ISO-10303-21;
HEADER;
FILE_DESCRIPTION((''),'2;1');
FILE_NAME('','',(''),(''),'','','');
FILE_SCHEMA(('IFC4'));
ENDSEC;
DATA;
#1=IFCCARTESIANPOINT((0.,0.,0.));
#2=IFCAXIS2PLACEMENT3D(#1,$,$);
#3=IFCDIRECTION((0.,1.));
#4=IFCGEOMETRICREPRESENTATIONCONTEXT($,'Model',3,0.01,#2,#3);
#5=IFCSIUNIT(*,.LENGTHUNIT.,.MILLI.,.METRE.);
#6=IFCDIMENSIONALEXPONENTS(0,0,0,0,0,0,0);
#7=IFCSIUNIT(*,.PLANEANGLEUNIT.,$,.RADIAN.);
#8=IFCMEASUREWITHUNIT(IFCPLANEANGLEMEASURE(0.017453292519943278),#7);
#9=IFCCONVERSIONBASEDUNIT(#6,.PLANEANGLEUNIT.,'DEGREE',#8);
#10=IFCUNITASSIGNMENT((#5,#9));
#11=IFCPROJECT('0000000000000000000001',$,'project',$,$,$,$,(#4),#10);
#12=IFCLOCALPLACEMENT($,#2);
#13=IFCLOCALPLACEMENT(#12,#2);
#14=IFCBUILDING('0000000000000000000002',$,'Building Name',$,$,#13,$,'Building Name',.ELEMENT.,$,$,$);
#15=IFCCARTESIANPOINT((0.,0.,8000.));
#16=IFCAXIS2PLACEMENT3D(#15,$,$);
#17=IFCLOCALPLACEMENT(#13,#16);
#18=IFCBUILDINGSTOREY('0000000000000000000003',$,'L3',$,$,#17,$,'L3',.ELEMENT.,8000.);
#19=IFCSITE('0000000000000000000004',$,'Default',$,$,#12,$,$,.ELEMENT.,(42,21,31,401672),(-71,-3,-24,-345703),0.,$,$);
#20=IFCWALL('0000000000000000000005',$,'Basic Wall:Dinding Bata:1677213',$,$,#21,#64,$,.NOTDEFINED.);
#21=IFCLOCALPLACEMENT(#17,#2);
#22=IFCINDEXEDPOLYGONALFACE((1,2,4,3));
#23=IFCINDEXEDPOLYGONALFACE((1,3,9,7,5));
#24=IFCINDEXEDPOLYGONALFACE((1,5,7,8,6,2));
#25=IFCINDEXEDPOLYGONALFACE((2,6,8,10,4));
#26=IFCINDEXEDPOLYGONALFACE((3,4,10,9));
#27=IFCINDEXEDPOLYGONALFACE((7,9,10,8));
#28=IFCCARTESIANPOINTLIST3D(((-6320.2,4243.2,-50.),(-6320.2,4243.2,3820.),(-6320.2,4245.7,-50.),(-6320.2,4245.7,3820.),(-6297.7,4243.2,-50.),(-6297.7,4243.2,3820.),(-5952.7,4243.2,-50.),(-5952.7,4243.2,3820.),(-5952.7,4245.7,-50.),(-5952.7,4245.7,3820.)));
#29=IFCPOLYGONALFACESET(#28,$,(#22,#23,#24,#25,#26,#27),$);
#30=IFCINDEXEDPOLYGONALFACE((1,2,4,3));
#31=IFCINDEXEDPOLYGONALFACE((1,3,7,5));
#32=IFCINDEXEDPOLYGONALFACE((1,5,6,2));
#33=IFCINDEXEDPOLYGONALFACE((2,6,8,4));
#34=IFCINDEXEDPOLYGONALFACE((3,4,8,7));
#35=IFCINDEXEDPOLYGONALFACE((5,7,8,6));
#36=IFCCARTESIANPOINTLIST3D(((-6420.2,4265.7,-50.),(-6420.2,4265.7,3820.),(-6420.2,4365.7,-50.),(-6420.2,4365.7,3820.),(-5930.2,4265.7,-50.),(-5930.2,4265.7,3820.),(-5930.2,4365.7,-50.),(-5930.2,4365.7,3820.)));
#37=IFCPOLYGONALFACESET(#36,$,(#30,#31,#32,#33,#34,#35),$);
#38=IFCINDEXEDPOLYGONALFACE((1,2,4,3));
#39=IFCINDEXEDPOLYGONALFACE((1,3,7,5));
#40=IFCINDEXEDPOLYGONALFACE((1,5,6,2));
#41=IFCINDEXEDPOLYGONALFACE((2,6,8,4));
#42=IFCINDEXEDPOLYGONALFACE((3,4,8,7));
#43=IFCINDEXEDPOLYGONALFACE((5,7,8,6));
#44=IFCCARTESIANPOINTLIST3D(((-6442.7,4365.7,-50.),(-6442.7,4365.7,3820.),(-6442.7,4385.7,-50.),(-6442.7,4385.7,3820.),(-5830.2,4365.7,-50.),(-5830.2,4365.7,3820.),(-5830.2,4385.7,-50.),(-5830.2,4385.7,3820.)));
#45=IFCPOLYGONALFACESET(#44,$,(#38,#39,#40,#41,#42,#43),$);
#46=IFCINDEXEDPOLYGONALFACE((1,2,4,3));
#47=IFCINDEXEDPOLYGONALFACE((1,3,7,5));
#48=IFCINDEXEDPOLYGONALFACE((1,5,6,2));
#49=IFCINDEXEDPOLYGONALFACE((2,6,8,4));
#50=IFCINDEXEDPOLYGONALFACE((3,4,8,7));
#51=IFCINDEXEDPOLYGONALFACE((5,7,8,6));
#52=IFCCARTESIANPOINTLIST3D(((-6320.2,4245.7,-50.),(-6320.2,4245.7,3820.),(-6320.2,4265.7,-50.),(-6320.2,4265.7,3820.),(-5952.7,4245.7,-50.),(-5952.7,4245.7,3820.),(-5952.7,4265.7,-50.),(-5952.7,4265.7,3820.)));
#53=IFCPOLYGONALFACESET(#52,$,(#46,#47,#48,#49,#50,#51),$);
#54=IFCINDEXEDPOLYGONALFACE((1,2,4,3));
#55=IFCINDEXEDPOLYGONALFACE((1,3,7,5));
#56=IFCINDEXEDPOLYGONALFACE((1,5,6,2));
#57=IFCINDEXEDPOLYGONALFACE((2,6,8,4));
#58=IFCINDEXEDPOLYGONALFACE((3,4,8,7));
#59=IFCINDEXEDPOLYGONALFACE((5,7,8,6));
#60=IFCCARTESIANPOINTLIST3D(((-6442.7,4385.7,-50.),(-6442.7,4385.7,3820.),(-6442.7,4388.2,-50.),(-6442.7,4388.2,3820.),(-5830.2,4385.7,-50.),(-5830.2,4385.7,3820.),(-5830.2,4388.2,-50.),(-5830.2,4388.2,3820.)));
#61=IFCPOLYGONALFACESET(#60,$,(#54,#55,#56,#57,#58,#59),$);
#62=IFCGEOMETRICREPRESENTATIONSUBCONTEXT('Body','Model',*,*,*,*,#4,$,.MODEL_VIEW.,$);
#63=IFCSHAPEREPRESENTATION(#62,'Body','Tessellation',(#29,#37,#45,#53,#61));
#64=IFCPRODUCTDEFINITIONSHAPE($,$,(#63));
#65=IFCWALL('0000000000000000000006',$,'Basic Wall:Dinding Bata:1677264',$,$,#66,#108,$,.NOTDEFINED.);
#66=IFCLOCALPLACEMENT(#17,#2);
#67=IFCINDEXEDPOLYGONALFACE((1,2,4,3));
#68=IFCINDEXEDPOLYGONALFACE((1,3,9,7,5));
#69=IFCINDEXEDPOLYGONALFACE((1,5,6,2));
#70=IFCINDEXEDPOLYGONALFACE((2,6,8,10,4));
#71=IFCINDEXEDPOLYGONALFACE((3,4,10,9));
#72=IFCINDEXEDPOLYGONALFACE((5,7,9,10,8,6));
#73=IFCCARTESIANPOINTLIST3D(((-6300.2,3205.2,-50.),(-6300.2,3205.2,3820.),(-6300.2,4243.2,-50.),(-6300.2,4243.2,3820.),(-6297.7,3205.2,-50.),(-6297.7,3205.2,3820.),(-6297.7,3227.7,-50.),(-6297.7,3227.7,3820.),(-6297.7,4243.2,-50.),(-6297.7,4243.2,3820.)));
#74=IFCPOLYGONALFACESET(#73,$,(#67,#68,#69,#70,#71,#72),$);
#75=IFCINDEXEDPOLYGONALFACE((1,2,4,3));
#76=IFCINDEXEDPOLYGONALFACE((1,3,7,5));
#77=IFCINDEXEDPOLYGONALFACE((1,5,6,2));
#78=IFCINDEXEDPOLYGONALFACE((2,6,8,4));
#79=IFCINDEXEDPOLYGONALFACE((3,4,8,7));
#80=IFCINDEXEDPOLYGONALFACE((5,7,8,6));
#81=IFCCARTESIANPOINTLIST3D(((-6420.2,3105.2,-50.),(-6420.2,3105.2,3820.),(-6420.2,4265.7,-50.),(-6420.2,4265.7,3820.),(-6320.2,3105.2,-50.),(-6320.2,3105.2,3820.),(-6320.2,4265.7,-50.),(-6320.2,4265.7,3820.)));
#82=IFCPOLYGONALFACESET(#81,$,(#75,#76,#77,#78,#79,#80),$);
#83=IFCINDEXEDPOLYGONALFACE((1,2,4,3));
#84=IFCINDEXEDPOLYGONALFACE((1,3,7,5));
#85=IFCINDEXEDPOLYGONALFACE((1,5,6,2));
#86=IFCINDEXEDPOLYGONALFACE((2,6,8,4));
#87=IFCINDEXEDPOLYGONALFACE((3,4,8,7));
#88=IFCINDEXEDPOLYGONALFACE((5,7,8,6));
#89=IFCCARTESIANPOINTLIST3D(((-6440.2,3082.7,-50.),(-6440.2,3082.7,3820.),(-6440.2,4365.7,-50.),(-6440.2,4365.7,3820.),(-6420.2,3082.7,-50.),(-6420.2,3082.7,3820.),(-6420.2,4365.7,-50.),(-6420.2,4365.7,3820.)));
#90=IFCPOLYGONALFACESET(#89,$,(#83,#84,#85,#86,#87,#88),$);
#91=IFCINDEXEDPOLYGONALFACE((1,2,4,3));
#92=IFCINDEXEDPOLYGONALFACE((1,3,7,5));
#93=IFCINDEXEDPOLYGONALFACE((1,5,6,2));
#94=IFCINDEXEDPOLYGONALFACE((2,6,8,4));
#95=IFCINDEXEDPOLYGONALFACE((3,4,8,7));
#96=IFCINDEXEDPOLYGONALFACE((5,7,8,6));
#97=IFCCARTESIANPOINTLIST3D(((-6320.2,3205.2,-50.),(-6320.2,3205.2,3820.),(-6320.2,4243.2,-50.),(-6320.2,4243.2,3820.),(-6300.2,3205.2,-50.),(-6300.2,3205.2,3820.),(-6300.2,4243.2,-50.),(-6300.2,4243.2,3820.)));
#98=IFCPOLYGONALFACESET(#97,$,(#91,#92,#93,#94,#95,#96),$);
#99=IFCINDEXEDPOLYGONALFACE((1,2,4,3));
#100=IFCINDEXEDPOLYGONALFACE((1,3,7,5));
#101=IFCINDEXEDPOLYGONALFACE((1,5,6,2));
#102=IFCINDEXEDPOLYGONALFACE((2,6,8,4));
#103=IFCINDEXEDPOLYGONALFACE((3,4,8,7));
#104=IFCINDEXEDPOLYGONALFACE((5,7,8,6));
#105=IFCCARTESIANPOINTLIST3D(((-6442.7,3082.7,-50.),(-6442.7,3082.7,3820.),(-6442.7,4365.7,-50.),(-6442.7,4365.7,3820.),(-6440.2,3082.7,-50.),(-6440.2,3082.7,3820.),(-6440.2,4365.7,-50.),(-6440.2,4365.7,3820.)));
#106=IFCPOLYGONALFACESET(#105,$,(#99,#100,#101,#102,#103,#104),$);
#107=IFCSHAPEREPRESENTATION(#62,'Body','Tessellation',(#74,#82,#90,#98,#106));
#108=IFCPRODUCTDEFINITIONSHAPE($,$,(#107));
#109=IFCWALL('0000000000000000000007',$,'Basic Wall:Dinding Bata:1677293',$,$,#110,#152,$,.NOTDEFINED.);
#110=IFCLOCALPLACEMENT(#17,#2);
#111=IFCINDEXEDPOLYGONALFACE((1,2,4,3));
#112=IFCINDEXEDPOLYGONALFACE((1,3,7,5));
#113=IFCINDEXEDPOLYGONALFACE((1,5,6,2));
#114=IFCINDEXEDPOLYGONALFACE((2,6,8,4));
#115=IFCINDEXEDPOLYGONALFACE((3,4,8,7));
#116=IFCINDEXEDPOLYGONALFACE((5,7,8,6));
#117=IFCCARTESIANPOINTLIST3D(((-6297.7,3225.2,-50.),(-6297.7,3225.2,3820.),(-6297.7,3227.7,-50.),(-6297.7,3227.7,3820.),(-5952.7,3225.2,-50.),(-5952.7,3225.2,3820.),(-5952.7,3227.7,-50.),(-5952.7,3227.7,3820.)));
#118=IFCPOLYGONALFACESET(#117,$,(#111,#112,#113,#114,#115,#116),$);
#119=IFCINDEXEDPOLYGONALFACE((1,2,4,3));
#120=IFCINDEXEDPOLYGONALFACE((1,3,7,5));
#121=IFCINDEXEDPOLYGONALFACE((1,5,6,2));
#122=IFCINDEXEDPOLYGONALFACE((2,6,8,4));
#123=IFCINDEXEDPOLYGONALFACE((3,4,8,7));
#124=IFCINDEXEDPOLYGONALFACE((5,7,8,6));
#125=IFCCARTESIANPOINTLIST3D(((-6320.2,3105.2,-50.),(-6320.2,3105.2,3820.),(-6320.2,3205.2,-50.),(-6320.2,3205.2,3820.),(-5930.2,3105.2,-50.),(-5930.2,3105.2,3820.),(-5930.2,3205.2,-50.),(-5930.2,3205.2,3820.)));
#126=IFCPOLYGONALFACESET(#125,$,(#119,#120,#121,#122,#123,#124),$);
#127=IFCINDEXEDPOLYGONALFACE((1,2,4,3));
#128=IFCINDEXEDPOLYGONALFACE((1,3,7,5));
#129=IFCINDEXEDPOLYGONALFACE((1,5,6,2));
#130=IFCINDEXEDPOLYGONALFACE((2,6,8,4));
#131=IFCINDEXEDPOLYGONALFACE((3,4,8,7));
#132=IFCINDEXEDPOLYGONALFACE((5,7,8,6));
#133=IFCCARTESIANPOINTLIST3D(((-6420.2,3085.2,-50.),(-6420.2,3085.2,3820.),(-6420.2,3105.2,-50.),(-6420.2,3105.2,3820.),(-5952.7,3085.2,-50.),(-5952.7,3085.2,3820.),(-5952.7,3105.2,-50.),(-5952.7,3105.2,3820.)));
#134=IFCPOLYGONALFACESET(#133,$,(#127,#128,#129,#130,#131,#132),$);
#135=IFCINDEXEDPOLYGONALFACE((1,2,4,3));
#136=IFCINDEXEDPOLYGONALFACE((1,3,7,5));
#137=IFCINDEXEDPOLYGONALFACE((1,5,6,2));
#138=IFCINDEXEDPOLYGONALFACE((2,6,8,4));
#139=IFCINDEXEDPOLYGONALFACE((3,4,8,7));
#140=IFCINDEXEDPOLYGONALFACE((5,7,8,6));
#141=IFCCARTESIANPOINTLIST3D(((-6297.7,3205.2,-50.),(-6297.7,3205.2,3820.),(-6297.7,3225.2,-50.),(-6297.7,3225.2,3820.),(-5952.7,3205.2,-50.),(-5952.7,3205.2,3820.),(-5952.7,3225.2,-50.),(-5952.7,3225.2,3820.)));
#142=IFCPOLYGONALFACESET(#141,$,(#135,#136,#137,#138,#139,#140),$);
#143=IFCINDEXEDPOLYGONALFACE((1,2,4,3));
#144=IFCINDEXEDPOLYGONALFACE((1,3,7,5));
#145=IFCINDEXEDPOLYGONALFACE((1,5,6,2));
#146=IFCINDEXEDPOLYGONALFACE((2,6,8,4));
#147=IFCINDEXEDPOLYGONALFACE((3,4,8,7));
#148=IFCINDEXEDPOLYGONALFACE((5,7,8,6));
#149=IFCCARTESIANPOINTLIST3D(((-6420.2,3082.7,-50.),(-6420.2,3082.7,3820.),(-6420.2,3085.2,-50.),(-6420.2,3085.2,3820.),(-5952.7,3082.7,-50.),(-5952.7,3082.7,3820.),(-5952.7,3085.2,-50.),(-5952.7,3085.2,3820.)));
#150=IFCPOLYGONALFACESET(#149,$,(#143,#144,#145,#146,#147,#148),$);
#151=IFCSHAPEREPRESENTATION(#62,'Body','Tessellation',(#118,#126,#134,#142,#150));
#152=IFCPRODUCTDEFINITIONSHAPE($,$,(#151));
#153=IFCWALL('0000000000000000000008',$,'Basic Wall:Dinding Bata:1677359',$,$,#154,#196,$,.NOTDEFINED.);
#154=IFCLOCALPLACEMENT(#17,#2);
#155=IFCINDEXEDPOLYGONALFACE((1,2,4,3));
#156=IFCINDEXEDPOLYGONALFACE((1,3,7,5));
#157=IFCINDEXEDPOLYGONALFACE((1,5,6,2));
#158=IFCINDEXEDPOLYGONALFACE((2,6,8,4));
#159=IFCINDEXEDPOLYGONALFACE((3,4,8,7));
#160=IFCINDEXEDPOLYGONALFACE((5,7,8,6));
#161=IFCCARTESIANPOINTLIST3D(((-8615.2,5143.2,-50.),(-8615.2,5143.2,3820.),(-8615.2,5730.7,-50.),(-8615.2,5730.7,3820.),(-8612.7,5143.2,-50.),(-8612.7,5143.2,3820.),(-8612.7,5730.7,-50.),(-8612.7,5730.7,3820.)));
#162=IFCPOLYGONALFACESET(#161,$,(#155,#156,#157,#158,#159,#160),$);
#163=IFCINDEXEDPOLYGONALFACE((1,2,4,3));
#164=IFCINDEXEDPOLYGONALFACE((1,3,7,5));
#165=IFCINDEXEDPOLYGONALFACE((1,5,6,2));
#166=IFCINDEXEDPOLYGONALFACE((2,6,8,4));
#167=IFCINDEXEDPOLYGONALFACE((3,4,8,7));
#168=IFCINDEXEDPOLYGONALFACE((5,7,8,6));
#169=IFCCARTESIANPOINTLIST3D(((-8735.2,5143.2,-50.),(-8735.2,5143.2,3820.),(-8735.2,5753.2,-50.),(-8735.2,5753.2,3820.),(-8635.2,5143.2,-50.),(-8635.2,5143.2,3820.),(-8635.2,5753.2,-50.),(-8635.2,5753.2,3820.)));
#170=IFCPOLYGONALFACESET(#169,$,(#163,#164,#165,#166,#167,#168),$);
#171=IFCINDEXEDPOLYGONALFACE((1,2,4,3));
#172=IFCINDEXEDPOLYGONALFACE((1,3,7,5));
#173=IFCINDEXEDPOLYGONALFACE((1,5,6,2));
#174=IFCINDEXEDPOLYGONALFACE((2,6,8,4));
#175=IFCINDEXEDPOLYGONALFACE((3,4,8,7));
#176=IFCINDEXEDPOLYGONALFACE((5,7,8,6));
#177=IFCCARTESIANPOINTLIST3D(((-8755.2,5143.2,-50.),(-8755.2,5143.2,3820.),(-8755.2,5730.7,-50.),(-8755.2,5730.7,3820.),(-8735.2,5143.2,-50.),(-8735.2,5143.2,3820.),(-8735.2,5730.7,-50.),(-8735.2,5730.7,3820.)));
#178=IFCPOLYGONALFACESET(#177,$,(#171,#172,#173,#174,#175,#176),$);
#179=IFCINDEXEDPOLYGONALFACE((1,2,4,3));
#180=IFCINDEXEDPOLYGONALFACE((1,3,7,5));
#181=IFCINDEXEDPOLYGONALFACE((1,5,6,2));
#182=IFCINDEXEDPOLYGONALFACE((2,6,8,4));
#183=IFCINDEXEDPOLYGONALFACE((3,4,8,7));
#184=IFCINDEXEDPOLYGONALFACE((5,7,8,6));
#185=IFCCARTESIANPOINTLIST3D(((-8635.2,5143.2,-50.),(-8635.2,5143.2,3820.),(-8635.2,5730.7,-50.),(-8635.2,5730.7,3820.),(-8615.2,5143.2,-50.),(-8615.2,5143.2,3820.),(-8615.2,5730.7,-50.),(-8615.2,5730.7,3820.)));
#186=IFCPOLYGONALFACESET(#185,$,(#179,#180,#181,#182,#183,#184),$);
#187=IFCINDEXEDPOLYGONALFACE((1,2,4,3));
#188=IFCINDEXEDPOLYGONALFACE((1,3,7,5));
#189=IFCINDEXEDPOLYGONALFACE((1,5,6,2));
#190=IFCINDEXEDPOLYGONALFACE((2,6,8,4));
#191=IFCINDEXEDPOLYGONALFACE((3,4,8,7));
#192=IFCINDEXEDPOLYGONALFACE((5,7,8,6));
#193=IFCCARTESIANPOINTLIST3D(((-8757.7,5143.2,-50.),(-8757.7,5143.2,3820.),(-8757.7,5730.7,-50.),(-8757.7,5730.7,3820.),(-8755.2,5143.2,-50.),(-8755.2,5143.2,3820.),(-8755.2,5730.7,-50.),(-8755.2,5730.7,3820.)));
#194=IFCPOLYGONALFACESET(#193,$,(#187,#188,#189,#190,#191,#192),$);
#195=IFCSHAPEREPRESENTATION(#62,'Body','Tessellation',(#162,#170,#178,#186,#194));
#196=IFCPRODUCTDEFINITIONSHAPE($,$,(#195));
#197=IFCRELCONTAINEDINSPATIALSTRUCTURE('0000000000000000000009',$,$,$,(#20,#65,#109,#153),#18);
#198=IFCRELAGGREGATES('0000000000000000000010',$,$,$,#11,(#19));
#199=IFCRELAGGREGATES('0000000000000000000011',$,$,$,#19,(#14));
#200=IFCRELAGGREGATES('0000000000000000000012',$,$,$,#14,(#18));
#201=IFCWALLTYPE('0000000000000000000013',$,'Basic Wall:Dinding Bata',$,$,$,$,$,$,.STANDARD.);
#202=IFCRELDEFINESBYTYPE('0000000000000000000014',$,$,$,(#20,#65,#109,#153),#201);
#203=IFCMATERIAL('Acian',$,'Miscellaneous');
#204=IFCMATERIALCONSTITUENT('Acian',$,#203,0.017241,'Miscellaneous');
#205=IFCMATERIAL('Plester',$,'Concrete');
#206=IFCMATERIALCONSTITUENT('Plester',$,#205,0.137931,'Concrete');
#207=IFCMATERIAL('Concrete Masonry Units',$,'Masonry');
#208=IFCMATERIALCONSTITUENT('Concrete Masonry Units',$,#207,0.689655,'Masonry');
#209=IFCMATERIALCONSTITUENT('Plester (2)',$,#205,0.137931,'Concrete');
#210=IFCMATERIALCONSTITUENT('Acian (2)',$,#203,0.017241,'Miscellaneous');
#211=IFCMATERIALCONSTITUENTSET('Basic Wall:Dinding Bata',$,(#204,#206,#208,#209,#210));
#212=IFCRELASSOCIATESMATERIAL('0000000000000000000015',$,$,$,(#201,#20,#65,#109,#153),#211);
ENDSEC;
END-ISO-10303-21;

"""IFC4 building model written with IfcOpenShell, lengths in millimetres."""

from ifc_helpers import new_model, entity, si_unit, converted_unit, direction, frame, origin, place, context, subcontext, project, spatial, indexed_curve, outline, extrude, material, constituent, constituent_set, type_object, element, save


model = new_model("IFC4")

# Units and contexts
model_context = context("Model", 3, precision=0.01, world=origin(), true_north=direction((0.0, 1.0)))
body_context = subcontext(model_context, "Body", "Model", "MODEL_VIEW")
ifc_project = project(units=[si_unit("LENGTHUNIT", "METRE", prefix="MILLI"), converted_unit("PLANEANGLEUNIT", "DEGREE", entity("IfcPlaneAngleMeasure", 0.017453292519943278), si_unit("PLANEANGLEUNIT", "RADIAN"), dimensions=[0, 0, 0, 0, 0, 0, 0])], contexts=[model_context])

# Site, building, storey
site_placement = place(None, origin())
site = spatial("IfcSite", under=ifc_project, at=site_placement, Name="Default", CompositionType="ELEMENT", RefLatitude=(42, 21, 31, 401672), RefLongitude=(-71, -3, -24, -345703), RefElevation=0.0)
building_placement = place(site_placement, origin())
building = spatial("IfcBuilding", under=site, at=building_placement, Name="Building Name", LongName="Building Name", CompositionType="ELEMENT")
storey_placement = place(building_placement, frame((0.0, 0.0, 8000.0)))
storey = spatial("IfcBuildingStorey", under=building, at=storey_placement, Name="L3", LongName="L3", CompositionType="ELEMENT", Elevation=8000.0)

# Walls
ifc_material_1 = material(Name="Acian", Category="Miscellaneous")
ifc_constituent_1 = constituent(ifc_material_1, Name="Acian", Category="Miscellaneous", fraction=0.017241)
ifc_material_2 = material(Name="Plester", Category="Concrete")
ifc_constituent_2 = constituent(ifc_material_2, Name="Plester", Category="Concrete", fraction=0.137931)
ifc_material_3 = material(Name="Concrete Masonry Units", Category="Masonry")
ifc_constituent_3 = constituent(ifc_material_3, Name="Concrete Masonry Units", Category="Masonry", fraction=0.689655)
ifc_constituent_4 = constituent(ifc_material_2, Name="Plester (2)", Category="Concrete", fraction=0.137931)
ifc_constituent_5 = constituent(ifc_material_1, Name="Acian (2)", Category="Miscellaneous", fraction=0.017241)
ifc_constituent_set = constituent_set(constituents=[ifc_constituent_1, ifc_constituent_2, ifc_constituent_3, ifc_constituent_4, ifc_constituent_5], Name="Basic Wall:Dinding Bata")
wall_type = type_object("IfcWallType", Name="Basic Wall:Dinding Bata", PredefinedType="STANDARD", material=ifc_constituent_set)
wall_1_placement = place(storey_placement, frame((-5952.7, 4315.7, -50.0), z_axis=(0.0, 0.0, 1.0), x_axis=(-1.0, 0.0, 0.0)))
element("IfcWall", 1, at=wall_1_placement, inside=storey, type_object=wall_type, material=ifc_constituent_set, Name="Basic Wall:Dinding Bata:1677213", PredefinedType="NOTDEFINED", context=body_context, shape_type="SweptSolid", body=[
    extrude(outline(indexed_curve([(-129.0, -1.0), (216.0, -1.0), (216.0, 1.5), (-151.5, 1.5), (-151.5, -1.0), (-129.0, -1.0)], self_intersect=False)), frame((216.0, 71.5, 0.0), z_axis=(0.0, 0.0, 1.0), x_axis=(-1.0, 0.0, 0.0)), (0.0, 0.0, 1.0), 3870.0),
    extrude(outline(indexed_curve([(-245.0, -50.0), (245.0, -50.0), (245.0, 50.0), (-245.0, 50.0), (-245.0, -50.0)], self_intersect=False)), frame((222.5, 0.0, 0.0)), (0.0, 0.0, 1.0), 3870.0),
    extrude(outline(indexed_curve([(-306.3, -10.0), (306.3, -10.0), (306.3, 10.0), (-306.3, 10.0), (-306.3, -10.0)], self_intersect=False)), frame((183.8, -60.0, 0.0)), (0.0, 0.0, 1.0), 3870.0),
    extrude(outline(indexed_curve([(-183.8, -10.0), (183.8, -10.0), (183.8, 10.0), (-183.8, 10.0), (-183.8, -10.0)], self_intersect=False)), frame((183.8, 60.0, 0.0)), (0.0, 0.0, 1.0), 3870.0),
    extrude(outline(indexed_curve([(-1.3, -306.3), (1.2, -306.3), (1.3, 306.3), (-1.2, 306.3), (-1.3, -306.3)], self_intersect=False)), frame((183.8, -71.3, 0.0), z_axis=(0.0, 0.0, 1.0), x_axis=(0.0, 1.0, 0.0)), (0.0, 0.0, 1.0), 3870.0),
])
wall_2_placement = place(storey_placement, frame((-6370.2, 4243.2, -50.0), z_axis=(0.0, 0.0, 1.0), x_axis=(0.0, -1.0, 0.0)))
element("IfcWall", 2, at=wall_2_placement, inside=storey, type_object=wall_type, material=ifc_constituent_set, Name="Basic Wall:Dinding Bata:1677264", PredefinedType="NOTDEFINED", context=body_context, shape_type="SweptSolid", body=[
    extrude(outline(indexed_curve([(-397.2, -1.0), (618.3, -1.0), (618.3, 1.5), (-419.7, 1.5), (-419.7, -1.0), (-397.2, -1.0)], self_intersect=False)), frame((618.3, 71.5, 0.0), z_axis=(0.0, 0.0, 1.0), x_axis=(-1.0, 0.0, 0.0)), (0.0, 0.0, 1.0), 3870.0),
    extrude(outline(indexed_curve([(-580.2, -50.0), (580.2, -50.0), (580.2, 50.0), (-580.2, 50.0), (-580.2, -50.0)], self_intersect=False)), frame((557.7, 0.0, 0.0)), (0.0, 0.0, 1.0), 3870.0),
    extrude(outline(indexed_curve([(-641.5, -10.0), (641.5, -10.0), (641.5, 10.0), (-641.5, 10.0), (-641.5, -10.0)], self_intersect=False)), frame((519.0, -60.0, 0.0)), (0.0, 0.0, 1.0), 3870.0),
    extrude(outline(indexed_curve([(-519.0, -10.0), (519.0, -10.0), (519.0, 10.0), (-519.0, 10.0), (-519.0, -10.0)], self_intersect=False)), frame((519.0, 60.0, 0.0)), (0.0, 0.0, 1.0), 3870.0),
    extrude(outline(indexed_curve([(-1.3, -641.5), (1.2, -641.5), (1.3, 641.5), (-1.2, 641.5), (-1.3, -641.5)], self_intersect=False)), frame((519.0, -71.3, 0.0), z_axis=(0.0, 0.0, 1.0), x_axis=(0.0, 1.0, 0.0)), (0.0, 0.0, 1.0), 3870.0),
])
wall_3_placement = place(storey_placement, frame((-6297.7, 3155.2, -50.0)))
element("IfcWall", 3, at=wall_3_placement, inside=storey, type_object=wall_type, material=ifc_constituent_set, Name="Basic Wall:Dinding Bata:1677293", PredefinedType="NOTDEFINED", context=body_context, shape_type="SweptSolid", body=[
    extrude(outline(indexed_curve([(-1.3, -172.5), (1.2, -172.5), (1.3, 172.5), (-1.2, 172.5), (-1.3, -172.5)], self_intersect=False)), frame((172.5, 71.3, 0.0), z_axis=(0.0, 0.0, 1.0), x_axis=(0.0, -1.0, 0.0)), (0.0, 0.0, 1.0), 3870.0),
    extrude(outline(indexed_curve([(-195.0, -50.0), (195.0, -50.0), (195.0, 50.0), (-195.0, 50.0), (-195.0, -50.0)], self_intersect=False)), frame((172.5, 0.0, 0.0)), (0.0, 0.0, 1.0), 3870.0),
    extrude(outline(indexed_curve([(-233.8, -10.0), (233.8, -10.0), (233.8, 10.0), (-233.8, 10.0), (-233.8, -10.0)], self_intersect=False)), frame((111.3, -60.0, 0.0)), (0.0, 0.0, 1.0), 3870.0),
    extrude(outline(indexed_curve([(-172.5, -10.0), (172.5, -10.0), (172.5, 10.0), (-172.5, 10.0), (-172.5, -10.0)], self_intersect=False)), frame((172.5, 60.0, 0.0)), (0.0, 0.0, 1.0), 3870.0),
    extrude(outline(indexed_curve([(-1.3, -233.8), (1.2, -233.8), (1.3, 233.8), (-1.2, 233.8), (-1.3, -233.8)], self_intersect=False)), frame((111.3, -71.3, 0.0), z_axis=(0.0, 0.0, 1.0), x_axis=(0.0, 1.0, 0.0)), (0.0, 0.0, 1.0), 3870.0),
])
wall_4_placement = place(storey_placement, frame((-8685.2, 5730.7, -50.0), z_axis=(0.0, 0.0, 1.0), x_axis=(0.0, -1.0, 0.0)))
element("IfcWall", 4, at=wall_4_placement, inside=storey, type_object=wall_type, material=ifc_constituent_set, Name="Basic Wall:Dinding Bata:1677359", PredefinedType="NOTDEFINED", context=body_context, shape_type="SweptSolid", body=[
    extrude(outline(indexed_curve([(-1.3, -293.8), (1.2, -293.8), (1.2, 293.7), (-1.2, 293.7), (-1.3, -293.8)], self_intersect=False)), frame((293.8, 71.2, 0.0), z_axis=(0.0, 0.0, 1.0), x_axis=(0.0, -1.0, 0.0)), (0.0, 0.0, 1.0), 3870.0),
    extrude(outline(indexed_curve([(-305.0, -50.0), (305.0, -50.0), (305.0, 50.0), (-305.0, 50.0), (-305.0, -50.0)], self_intersect=False)), frame((282.5, 0.0, 0.0)), (0.0, 0.0, 1.0), 3870.0),
    extrude(outline(indexed_curve([(-293.8, -10.0), (293.8, -10.0), (293.8, 10.0), (-293.8, 10.0), (-293.8, -10.0)], self_intersect=False)), frame((293.8, -60.0, 0.0)), (0.0, 0.0, 1.0), 3870.0),
    extrude(outline(indexed_curve([(-293.8, -10.0), (293.7, -10.0), (293.7, 10.0), (-293.8, 10.0), (-293.8, -10.0)], self_intersect=False)), frame((293.8, 60.0, 0.0)), (0.0, 0.0, 1.0), 3870.0),
    extrude(outline(indexed_curve([(-1.2, -293.8), (1.2, -293.8), (1.3, 293.8), (-1.2, 293.8), (-1.2, -293.8)], self_intersect=False)), frame((293.8, -71.3, 0.0), z_axis=(0.0, 0.0, 1.0), x_axis=(0.0, 1.0, 0.0)), (0.0, 0.0, 1.0), 3870.0),
])

save(model, "model.ifc")
